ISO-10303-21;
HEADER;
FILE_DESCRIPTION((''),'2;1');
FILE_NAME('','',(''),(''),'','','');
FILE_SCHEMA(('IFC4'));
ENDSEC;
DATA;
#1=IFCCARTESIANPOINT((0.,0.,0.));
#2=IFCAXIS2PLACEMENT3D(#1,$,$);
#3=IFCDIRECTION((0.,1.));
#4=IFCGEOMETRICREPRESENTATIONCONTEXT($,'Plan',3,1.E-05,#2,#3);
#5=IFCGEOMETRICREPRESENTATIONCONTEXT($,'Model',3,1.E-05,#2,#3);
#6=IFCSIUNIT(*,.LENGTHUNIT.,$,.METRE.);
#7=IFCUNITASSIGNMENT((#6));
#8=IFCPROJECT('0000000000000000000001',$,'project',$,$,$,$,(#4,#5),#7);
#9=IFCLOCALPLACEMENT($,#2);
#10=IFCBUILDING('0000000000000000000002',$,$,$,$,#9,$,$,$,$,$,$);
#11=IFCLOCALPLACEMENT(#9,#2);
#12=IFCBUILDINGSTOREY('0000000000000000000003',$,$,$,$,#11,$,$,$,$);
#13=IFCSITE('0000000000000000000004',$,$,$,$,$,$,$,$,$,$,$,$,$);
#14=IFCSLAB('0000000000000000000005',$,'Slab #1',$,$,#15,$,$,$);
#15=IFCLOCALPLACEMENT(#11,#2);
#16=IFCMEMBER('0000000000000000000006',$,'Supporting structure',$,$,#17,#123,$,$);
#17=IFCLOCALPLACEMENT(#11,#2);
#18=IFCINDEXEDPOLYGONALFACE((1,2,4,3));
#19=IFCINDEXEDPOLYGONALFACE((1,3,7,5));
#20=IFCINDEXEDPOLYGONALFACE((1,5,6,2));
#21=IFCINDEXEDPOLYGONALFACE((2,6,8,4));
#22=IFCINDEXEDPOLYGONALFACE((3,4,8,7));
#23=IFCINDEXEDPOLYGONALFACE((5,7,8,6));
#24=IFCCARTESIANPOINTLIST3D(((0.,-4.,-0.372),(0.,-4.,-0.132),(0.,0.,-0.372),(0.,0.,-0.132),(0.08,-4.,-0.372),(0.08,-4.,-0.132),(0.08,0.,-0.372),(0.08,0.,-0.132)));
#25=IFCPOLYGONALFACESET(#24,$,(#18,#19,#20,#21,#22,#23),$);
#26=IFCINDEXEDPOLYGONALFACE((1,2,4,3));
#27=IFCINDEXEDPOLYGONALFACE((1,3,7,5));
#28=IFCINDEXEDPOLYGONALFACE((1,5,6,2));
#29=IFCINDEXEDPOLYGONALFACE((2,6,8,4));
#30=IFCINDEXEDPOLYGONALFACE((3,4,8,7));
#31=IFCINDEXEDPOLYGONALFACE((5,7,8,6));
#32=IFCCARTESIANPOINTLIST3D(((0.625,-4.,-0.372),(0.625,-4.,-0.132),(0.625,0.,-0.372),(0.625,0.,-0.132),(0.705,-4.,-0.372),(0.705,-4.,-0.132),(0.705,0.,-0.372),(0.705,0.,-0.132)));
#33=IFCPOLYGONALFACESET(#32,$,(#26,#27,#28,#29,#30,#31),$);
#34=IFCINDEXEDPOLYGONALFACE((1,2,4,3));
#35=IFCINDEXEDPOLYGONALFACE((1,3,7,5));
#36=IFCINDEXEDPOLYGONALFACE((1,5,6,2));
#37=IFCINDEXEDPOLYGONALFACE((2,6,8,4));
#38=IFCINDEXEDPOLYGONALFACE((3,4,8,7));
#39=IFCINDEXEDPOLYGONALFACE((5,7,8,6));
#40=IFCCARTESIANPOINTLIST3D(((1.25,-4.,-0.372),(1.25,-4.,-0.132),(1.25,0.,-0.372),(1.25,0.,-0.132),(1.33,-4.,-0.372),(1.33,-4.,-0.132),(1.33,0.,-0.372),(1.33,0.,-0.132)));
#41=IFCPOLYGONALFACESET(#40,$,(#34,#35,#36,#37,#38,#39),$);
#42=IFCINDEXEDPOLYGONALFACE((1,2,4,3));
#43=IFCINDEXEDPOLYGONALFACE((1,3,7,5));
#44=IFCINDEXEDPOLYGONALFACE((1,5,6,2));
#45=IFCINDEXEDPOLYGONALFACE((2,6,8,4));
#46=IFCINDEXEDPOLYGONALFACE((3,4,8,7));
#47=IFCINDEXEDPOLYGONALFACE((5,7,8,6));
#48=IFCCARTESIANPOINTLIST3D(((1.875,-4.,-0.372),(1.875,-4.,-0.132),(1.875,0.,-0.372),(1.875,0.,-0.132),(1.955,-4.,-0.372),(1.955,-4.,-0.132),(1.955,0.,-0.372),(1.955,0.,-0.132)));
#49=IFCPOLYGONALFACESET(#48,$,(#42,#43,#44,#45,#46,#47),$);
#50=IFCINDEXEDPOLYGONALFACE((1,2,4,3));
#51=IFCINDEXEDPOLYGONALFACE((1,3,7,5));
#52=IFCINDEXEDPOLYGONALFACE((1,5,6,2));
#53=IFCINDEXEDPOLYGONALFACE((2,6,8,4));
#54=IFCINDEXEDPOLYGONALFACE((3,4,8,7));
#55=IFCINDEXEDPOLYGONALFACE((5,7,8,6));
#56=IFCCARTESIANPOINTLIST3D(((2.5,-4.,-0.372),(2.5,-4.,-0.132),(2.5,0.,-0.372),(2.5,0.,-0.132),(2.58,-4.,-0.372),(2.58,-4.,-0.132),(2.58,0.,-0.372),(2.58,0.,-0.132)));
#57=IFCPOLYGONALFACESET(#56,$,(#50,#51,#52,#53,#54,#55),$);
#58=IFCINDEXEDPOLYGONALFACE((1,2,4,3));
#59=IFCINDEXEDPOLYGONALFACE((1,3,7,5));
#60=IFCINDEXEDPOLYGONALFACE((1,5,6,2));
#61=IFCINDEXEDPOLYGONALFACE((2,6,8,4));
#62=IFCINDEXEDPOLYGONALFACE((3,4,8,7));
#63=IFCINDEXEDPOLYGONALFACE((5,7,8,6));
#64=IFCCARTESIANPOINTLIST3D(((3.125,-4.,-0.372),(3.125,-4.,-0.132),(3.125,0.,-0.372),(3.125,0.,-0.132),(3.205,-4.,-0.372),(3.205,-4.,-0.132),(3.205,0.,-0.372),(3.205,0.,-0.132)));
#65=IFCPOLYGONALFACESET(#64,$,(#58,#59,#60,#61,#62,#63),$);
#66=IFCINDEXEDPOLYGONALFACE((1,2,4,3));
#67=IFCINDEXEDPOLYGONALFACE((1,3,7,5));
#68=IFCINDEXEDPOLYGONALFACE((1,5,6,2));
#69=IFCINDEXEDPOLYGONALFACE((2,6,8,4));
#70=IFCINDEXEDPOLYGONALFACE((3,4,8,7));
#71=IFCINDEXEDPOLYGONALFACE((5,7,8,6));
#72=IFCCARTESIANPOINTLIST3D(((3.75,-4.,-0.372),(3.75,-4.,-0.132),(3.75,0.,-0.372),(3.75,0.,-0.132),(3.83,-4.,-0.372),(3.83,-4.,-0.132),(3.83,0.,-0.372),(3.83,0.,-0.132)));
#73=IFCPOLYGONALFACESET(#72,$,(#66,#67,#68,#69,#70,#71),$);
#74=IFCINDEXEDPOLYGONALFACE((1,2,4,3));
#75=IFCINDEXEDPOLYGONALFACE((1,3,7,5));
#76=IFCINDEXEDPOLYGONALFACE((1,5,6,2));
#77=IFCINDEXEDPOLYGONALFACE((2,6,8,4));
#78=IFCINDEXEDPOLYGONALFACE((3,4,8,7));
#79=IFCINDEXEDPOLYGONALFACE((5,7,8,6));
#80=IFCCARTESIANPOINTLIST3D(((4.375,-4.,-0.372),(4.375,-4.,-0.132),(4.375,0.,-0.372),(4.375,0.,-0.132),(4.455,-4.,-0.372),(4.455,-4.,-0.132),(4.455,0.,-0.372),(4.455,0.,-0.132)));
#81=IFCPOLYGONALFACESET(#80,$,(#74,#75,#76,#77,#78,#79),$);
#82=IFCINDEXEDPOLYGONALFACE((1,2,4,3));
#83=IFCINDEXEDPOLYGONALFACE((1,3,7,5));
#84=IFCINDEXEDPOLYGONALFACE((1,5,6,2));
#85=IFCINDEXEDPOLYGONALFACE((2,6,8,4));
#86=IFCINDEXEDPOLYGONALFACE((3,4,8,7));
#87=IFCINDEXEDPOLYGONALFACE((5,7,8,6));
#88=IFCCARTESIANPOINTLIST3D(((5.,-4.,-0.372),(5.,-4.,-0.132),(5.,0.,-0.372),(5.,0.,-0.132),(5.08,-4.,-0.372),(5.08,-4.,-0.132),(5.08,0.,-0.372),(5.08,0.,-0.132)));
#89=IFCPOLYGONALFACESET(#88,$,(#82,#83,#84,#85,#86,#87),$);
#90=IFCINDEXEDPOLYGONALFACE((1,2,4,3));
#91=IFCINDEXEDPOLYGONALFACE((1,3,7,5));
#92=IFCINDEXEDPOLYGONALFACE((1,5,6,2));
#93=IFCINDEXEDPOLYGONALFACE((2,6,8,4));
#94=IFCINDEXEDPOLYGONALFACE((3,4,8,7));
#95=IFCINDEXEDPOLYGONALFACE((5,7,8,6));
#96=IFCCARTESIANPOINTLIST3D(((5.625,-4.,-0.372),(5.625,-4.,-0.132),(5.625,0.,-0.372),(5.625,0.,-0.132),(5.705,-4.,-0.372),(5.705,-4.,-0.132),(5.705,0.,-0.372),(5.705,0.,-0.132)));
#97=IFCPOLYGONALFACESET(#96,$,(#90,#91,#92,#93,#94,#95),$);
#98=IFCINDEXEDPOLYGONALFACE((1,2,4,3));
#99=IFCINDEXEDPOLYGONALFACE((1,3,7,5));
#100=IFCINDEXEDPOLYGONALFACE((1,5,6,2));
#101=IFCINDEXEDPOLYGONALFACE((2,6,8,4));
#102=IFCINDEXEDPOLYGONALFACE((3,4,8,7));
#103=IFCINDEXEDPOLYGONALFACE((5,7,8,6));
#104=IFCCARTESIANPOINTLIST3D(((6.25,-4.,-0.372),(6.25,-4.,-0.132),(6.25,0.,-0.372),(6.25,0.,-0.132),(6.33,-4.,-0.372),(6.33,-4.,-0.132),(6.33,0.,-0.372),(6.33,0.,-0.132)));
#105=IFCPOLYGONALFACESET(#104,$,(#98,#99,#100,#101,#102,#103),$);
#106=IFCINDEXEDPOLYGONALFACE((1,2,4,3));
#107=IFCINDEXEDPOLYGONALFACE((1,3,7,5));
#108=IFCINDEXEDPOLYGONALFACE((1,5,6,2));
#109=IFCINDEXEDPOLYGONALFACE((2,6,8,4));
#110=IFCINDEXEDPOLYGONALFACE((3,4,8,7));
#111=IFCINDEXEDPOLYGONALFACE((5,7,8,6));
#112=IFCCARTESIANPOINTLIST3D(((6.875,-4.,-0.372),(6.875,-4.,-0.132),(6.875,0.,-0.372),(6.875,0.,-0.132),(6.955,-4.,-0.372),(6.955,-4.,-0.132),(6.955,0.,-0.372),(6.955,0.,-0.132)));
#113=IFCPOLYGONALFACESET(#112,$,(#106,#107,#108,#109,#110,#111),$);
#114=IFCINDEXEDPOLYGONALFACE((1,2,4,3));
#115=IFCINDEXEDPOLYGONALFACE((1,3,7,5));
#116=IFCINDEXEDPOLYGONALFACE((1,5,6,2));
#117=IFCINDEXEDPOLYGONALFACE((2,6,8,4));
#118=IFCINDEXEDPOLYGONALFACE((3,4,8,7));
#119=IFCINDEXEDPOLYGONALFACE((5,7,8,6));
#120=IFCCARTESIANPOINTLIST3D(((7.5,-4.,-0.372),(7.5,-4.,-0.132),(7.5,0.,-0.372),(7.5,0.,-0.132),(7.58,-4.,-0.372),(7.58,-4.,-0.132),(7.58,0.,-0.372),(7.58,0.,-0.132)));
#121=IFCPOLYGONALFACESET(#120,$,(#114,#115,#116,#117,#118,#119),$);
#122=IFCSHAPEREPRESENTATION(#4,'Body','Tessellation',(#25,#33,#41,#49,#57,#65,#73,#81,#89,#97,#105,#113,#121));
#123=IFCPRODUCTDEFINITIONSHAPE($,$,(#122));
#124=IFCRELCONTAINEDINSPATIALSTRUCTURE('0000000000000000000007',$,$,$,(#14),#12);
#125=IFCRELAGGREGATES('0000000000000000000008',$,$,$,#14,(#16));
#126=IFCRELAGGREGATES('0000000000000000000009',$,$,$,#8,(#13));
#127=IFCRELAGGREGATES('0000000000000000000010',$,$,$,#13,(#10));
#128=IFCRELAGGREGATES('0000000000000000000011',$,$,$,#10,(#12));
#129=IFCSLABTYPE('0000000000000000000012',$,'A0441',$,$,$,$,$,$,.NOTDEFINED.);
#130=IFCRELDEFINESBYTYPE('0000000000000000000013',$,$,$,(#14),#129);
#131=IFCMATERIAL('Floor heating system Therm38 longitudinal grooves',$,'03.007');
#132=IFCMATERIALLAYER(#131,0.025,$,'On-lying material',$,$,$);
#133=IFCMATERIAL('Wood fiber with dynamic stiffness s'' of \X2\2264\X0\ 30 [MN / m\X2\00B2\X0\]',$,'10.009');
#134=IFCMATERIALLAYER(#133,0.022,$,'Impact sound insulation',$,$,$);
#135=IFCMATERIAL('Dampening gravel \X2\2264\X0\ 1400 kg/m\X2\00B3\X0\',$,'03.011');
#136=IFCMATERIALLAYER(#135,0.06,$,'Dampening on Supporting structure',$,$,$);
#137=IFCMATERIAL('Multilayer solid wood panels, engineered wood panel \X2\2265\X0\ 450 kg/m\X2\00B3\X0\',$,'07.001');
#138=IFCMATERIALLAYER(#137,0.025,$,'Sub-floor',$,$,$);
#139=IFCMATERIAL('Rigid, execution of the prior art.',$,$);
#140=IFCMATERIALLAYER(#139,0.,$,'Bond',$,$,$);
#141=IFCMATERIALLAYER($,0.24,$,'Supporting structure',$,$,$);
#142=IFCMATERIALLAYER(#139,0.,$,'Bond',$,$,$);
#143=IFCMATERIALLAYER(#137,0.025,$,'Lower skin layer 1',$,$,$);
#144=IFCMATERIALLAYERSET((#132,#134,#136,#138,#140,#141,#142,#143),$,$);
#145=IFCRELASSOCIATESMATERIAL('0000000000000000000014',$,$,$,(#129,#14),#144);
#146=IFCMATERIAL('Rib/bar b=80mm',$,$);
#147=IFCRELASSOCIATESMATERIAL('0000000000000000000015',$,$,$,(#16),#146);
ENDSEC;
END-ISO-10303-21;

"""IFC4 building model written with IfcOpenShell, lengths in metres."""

from ifc_helpers import new_model, si_unit, direction, frame, frame_2d, origin, place, context, project, spatial, rectangle, extrude, material, layer, layer_set, type_object, element, aggregate, save


model = new_model("IFC4")

# Units and contexts
plan_context = context("Plan", 3, precision=1e-05, world=origin(), true_north=direction((0.0, 1.0)))
model_context = context("Model", 3, precision=1e-05, world=origin(), true_north=direction((0.0, 1.0)))
ifc_project = project(units=[si_unit("LENGTHUNIT", "METRE")], contexts=[plan_context, model_context])

# Site, building, storey
site = spatial("IfcSite", under=ifc_project)
building_placement = place(None, origin())
building = spatial("IfcBuilding", under=site, at=building_placement)
storey_placement = place(building_placement, origin())
storey = spatial("IfcBuildingStorey", under=building, at=storey_placement)

# Slab, member
ifc_material_1 = material(Name="Floor heating system Therm38 longitudinal grooves", Category="03.007")
ifc_layer_1 = layer(ifc_material_1, 0.025, Name="On-lying material")
ifc_material_2 = material(Name="Wood fiber with dynamic stiffness s' of ≤ 30 [MN / m²]", Category="10.009")
ifc_layer_2 = layer(ifc_material_2, 0.022, Name="Impact sound insulation")
ifc_material_3 = material(Name="Dampening gravel ≤ 1400 kg/m³", Category="03.011")
ifc_layer_3 = layer(ifc_material_3, 0.06, Name="Dampening on Supporting structure")
ifc_material_4 = material(Name="Multilayer solid wood panels, engineered wood panel ≥ 450 kg/m³", Category="07.001")
ifc_layer_4 = layer(ifc_material_4, 0.025, Name="Sub-floor")
ifc_material_5 = material(Name="Rigid, execution of the prior art.")
ifc_layer_5 = layer(ifc_material_5, 0.0, Name="Bond")
ifc_layer_6 = layer(None, 0.24, Name="Supporting structure")
ifc_layer_7 = layer(ifc_material_5, 0.0, Name="Bond")
ifc_layer_8 = layer(ifc_material_4, 0.025, Name="Lower skin layer 1")
ifc_layer_set = layer_set([ifc_layer_1, ifc_layer_2, ifc_layer_3, ifc_layer_4, ifc_layer_5, ifc_layer_6, ifc_layer_7, ifc_layer_8])
slab_type = type_object("IfcSlabType", Name="A0441", PredefinedType="NOTDEFINED", material=ifc_layer_set)
slab_placement = place(None, frame((0.0, 0.0, 0.0), z_axis=(0.0, 0.0, -1.0), x_axis=(1.0, 0.0, 0.0)))
slab = element("IfcSlab", 1, at=slab_placement, inside=storey, type_object=slab_type, material=ifc_layer_set, Name="Slab #1")
ifc_material_6 = material(Name="Rib/bar b=80mm")
member_1_placement = place(slab_placement, origin())
member_1 = element("IfcMember", 2, at=member_1_placement, material=ifc_material_6, Name="Supporting structure", context=plan_context, shape_type="SweptSolid", body=[
    extrude(rectangle(XDim=0.08, YDim=0.24, at=frame_2d((0.04, 0.12), x_axis=(1.0, 0.0))), frame((0.0, 4.0, 0.132), z_axis=(0.0, -1.0, 0.0), x_axis=(1.0, 0.0, 0.0)), (0.0, 0.0, 1.0), 4.0),
    extrude(rectangle(XDim=0.08, YDim=0.24, at=frame_2d((0.04, 0.12), x_axis=(1.0, 0.0))), frame((0.625, 4.0, 0.132), z_axis=(0.0, -1.0, 0.0), x_axis=(1.0, 0.0, 0.0)), (0.0, 0.0, 1.0), 4.0),
    extrude(rectangle(XDim=0.08, YDim=0.24, at=frame_2d((0.04, 0.12), x_axis=(1.0, 0.0))), frame((1.25, 4.0, 0.132), z_axis=(0.0, -1.0, 0.0), x_axis=(1.0, 0.0, 0.0)), (0.0, 0.0, 1.0), 4.0),
    extrude(rectangle(XDim=0.08, YDim=0.24, at=frame_2d((0.04, 0.12), x_axis=(1.0, 0.0))), frame((1.875, 4.0, 0.132), z_axis=(0.0, -1.0, 0.0), x_axis=(1.0, 0.0, 0.0)), (0.0, 0.0, 1.0), 4.0),
    extrude(rectangle(XDim=0.08, YDim=0.24, at=frame_2d((0.04, 0.12), x_axis=(1.0, 0.0))), frame((2.5, 4.0, 0.132), z_axis=(0.0, -1.0, 0.0), x_axis=(1.0, 0.0, 0.0)), (0.0, 0.0, 1.0), 4.0),
    extrude(rectangle(XDim=0.08, YDim=0.24, at=frame_2d((0.04, 0.12), x_axis=(1.0, 0.0))), frame((3.125, 4.0, 0.132), z_axis=(0.0, -1.0, 0.0), x_axis=(1.0, 0.0, 0.0)), (0.0, 0.0, 1.0), 4.0),
    extrude(rectangle(XDim=0.08, YDim=0.24, at=frame_2d((0.04, 0.12), x_axis=(1.0, 0.0))), frame((3.75, 4.0, 0.132), z_axis=(0.0, -1.0, 0.0), x_axis=(1.0, 0.0, 0.0)), (0.0, 0.0, 1.0), 4.0),
    extrude(rectangle(XDim=0.08, YDim=0.24, at=frame_2d((0.04, 0.12), x_axis=(1.0, 0.0))), frame((4.375, 4.0, 0.132), z_axis=(0.0, -1.0, 0.0), x_axis=(1.0, 0.0, 0.0)), (0.0, 0.0, 1.0), 4.0),
    extrude(rectangle(XDim=0.08, YDim=0.24, at=frame_2d((0.04, 0.12), x_axis=(1.0, 0.0))), frame((5.0, 4.0, 0.132), z_axis=(0.0, -1.0, 0.0), x_axis=(1.0, 0.0, 0.0)), (0.0, 0.0, 1.0), 4.0),
    extrude(rectangle(XDim=0.08, YDim=0.24, at=frame_2d((0.04, 0.12), x_axis=(1.0, 0.0))), frame((5.625, 4.0, 0.132), z_axis=(0.0, -1.0, 0.0), x_axis=(1.0, 0.0, 0.0)), (0.0, 0.0, 1.0), 4.0),
    extrude(rectangle(XDim=0.08, YDim=0.24, at=frame_2d((0.04, 0.12), x_axis=(1.0, 0.0))), frame((6.25, 4.0, 0.132), z_axis=(0.0, -1.0, 0.0), x_axis=(1.0, 0.0, 0.0)), (0.0, 0.0, 1.0), 4.0),
    extrude(rectangle(XDim=0.08, YDim=0.24, at=frame_2d((0.04, 0.12), x_axis=(1.0, 0.0))), frame((6.875, 4.0, 0.132), z_axis=(0.0, -1.0, 0.0), x_axis=(1.0, 0.0, 0.0)), (0.0, 0.0, 1.0), 4.0),
    extrude(rectangle(XDim=0.08, YDim=0.24, at=frame_2d((0.04, 0.12), x_axis=(1.0, 0.0))), frame((7.5, 4.0, 0.132), z_axis=(0.0, -1.0, 0.0), x_axis=(1.0, 0.0, 0.0)), (0.0, 0.0, 1.0), 4.0),
])
aggregate(slab, [member_1])

save(model, "model.ifc")
